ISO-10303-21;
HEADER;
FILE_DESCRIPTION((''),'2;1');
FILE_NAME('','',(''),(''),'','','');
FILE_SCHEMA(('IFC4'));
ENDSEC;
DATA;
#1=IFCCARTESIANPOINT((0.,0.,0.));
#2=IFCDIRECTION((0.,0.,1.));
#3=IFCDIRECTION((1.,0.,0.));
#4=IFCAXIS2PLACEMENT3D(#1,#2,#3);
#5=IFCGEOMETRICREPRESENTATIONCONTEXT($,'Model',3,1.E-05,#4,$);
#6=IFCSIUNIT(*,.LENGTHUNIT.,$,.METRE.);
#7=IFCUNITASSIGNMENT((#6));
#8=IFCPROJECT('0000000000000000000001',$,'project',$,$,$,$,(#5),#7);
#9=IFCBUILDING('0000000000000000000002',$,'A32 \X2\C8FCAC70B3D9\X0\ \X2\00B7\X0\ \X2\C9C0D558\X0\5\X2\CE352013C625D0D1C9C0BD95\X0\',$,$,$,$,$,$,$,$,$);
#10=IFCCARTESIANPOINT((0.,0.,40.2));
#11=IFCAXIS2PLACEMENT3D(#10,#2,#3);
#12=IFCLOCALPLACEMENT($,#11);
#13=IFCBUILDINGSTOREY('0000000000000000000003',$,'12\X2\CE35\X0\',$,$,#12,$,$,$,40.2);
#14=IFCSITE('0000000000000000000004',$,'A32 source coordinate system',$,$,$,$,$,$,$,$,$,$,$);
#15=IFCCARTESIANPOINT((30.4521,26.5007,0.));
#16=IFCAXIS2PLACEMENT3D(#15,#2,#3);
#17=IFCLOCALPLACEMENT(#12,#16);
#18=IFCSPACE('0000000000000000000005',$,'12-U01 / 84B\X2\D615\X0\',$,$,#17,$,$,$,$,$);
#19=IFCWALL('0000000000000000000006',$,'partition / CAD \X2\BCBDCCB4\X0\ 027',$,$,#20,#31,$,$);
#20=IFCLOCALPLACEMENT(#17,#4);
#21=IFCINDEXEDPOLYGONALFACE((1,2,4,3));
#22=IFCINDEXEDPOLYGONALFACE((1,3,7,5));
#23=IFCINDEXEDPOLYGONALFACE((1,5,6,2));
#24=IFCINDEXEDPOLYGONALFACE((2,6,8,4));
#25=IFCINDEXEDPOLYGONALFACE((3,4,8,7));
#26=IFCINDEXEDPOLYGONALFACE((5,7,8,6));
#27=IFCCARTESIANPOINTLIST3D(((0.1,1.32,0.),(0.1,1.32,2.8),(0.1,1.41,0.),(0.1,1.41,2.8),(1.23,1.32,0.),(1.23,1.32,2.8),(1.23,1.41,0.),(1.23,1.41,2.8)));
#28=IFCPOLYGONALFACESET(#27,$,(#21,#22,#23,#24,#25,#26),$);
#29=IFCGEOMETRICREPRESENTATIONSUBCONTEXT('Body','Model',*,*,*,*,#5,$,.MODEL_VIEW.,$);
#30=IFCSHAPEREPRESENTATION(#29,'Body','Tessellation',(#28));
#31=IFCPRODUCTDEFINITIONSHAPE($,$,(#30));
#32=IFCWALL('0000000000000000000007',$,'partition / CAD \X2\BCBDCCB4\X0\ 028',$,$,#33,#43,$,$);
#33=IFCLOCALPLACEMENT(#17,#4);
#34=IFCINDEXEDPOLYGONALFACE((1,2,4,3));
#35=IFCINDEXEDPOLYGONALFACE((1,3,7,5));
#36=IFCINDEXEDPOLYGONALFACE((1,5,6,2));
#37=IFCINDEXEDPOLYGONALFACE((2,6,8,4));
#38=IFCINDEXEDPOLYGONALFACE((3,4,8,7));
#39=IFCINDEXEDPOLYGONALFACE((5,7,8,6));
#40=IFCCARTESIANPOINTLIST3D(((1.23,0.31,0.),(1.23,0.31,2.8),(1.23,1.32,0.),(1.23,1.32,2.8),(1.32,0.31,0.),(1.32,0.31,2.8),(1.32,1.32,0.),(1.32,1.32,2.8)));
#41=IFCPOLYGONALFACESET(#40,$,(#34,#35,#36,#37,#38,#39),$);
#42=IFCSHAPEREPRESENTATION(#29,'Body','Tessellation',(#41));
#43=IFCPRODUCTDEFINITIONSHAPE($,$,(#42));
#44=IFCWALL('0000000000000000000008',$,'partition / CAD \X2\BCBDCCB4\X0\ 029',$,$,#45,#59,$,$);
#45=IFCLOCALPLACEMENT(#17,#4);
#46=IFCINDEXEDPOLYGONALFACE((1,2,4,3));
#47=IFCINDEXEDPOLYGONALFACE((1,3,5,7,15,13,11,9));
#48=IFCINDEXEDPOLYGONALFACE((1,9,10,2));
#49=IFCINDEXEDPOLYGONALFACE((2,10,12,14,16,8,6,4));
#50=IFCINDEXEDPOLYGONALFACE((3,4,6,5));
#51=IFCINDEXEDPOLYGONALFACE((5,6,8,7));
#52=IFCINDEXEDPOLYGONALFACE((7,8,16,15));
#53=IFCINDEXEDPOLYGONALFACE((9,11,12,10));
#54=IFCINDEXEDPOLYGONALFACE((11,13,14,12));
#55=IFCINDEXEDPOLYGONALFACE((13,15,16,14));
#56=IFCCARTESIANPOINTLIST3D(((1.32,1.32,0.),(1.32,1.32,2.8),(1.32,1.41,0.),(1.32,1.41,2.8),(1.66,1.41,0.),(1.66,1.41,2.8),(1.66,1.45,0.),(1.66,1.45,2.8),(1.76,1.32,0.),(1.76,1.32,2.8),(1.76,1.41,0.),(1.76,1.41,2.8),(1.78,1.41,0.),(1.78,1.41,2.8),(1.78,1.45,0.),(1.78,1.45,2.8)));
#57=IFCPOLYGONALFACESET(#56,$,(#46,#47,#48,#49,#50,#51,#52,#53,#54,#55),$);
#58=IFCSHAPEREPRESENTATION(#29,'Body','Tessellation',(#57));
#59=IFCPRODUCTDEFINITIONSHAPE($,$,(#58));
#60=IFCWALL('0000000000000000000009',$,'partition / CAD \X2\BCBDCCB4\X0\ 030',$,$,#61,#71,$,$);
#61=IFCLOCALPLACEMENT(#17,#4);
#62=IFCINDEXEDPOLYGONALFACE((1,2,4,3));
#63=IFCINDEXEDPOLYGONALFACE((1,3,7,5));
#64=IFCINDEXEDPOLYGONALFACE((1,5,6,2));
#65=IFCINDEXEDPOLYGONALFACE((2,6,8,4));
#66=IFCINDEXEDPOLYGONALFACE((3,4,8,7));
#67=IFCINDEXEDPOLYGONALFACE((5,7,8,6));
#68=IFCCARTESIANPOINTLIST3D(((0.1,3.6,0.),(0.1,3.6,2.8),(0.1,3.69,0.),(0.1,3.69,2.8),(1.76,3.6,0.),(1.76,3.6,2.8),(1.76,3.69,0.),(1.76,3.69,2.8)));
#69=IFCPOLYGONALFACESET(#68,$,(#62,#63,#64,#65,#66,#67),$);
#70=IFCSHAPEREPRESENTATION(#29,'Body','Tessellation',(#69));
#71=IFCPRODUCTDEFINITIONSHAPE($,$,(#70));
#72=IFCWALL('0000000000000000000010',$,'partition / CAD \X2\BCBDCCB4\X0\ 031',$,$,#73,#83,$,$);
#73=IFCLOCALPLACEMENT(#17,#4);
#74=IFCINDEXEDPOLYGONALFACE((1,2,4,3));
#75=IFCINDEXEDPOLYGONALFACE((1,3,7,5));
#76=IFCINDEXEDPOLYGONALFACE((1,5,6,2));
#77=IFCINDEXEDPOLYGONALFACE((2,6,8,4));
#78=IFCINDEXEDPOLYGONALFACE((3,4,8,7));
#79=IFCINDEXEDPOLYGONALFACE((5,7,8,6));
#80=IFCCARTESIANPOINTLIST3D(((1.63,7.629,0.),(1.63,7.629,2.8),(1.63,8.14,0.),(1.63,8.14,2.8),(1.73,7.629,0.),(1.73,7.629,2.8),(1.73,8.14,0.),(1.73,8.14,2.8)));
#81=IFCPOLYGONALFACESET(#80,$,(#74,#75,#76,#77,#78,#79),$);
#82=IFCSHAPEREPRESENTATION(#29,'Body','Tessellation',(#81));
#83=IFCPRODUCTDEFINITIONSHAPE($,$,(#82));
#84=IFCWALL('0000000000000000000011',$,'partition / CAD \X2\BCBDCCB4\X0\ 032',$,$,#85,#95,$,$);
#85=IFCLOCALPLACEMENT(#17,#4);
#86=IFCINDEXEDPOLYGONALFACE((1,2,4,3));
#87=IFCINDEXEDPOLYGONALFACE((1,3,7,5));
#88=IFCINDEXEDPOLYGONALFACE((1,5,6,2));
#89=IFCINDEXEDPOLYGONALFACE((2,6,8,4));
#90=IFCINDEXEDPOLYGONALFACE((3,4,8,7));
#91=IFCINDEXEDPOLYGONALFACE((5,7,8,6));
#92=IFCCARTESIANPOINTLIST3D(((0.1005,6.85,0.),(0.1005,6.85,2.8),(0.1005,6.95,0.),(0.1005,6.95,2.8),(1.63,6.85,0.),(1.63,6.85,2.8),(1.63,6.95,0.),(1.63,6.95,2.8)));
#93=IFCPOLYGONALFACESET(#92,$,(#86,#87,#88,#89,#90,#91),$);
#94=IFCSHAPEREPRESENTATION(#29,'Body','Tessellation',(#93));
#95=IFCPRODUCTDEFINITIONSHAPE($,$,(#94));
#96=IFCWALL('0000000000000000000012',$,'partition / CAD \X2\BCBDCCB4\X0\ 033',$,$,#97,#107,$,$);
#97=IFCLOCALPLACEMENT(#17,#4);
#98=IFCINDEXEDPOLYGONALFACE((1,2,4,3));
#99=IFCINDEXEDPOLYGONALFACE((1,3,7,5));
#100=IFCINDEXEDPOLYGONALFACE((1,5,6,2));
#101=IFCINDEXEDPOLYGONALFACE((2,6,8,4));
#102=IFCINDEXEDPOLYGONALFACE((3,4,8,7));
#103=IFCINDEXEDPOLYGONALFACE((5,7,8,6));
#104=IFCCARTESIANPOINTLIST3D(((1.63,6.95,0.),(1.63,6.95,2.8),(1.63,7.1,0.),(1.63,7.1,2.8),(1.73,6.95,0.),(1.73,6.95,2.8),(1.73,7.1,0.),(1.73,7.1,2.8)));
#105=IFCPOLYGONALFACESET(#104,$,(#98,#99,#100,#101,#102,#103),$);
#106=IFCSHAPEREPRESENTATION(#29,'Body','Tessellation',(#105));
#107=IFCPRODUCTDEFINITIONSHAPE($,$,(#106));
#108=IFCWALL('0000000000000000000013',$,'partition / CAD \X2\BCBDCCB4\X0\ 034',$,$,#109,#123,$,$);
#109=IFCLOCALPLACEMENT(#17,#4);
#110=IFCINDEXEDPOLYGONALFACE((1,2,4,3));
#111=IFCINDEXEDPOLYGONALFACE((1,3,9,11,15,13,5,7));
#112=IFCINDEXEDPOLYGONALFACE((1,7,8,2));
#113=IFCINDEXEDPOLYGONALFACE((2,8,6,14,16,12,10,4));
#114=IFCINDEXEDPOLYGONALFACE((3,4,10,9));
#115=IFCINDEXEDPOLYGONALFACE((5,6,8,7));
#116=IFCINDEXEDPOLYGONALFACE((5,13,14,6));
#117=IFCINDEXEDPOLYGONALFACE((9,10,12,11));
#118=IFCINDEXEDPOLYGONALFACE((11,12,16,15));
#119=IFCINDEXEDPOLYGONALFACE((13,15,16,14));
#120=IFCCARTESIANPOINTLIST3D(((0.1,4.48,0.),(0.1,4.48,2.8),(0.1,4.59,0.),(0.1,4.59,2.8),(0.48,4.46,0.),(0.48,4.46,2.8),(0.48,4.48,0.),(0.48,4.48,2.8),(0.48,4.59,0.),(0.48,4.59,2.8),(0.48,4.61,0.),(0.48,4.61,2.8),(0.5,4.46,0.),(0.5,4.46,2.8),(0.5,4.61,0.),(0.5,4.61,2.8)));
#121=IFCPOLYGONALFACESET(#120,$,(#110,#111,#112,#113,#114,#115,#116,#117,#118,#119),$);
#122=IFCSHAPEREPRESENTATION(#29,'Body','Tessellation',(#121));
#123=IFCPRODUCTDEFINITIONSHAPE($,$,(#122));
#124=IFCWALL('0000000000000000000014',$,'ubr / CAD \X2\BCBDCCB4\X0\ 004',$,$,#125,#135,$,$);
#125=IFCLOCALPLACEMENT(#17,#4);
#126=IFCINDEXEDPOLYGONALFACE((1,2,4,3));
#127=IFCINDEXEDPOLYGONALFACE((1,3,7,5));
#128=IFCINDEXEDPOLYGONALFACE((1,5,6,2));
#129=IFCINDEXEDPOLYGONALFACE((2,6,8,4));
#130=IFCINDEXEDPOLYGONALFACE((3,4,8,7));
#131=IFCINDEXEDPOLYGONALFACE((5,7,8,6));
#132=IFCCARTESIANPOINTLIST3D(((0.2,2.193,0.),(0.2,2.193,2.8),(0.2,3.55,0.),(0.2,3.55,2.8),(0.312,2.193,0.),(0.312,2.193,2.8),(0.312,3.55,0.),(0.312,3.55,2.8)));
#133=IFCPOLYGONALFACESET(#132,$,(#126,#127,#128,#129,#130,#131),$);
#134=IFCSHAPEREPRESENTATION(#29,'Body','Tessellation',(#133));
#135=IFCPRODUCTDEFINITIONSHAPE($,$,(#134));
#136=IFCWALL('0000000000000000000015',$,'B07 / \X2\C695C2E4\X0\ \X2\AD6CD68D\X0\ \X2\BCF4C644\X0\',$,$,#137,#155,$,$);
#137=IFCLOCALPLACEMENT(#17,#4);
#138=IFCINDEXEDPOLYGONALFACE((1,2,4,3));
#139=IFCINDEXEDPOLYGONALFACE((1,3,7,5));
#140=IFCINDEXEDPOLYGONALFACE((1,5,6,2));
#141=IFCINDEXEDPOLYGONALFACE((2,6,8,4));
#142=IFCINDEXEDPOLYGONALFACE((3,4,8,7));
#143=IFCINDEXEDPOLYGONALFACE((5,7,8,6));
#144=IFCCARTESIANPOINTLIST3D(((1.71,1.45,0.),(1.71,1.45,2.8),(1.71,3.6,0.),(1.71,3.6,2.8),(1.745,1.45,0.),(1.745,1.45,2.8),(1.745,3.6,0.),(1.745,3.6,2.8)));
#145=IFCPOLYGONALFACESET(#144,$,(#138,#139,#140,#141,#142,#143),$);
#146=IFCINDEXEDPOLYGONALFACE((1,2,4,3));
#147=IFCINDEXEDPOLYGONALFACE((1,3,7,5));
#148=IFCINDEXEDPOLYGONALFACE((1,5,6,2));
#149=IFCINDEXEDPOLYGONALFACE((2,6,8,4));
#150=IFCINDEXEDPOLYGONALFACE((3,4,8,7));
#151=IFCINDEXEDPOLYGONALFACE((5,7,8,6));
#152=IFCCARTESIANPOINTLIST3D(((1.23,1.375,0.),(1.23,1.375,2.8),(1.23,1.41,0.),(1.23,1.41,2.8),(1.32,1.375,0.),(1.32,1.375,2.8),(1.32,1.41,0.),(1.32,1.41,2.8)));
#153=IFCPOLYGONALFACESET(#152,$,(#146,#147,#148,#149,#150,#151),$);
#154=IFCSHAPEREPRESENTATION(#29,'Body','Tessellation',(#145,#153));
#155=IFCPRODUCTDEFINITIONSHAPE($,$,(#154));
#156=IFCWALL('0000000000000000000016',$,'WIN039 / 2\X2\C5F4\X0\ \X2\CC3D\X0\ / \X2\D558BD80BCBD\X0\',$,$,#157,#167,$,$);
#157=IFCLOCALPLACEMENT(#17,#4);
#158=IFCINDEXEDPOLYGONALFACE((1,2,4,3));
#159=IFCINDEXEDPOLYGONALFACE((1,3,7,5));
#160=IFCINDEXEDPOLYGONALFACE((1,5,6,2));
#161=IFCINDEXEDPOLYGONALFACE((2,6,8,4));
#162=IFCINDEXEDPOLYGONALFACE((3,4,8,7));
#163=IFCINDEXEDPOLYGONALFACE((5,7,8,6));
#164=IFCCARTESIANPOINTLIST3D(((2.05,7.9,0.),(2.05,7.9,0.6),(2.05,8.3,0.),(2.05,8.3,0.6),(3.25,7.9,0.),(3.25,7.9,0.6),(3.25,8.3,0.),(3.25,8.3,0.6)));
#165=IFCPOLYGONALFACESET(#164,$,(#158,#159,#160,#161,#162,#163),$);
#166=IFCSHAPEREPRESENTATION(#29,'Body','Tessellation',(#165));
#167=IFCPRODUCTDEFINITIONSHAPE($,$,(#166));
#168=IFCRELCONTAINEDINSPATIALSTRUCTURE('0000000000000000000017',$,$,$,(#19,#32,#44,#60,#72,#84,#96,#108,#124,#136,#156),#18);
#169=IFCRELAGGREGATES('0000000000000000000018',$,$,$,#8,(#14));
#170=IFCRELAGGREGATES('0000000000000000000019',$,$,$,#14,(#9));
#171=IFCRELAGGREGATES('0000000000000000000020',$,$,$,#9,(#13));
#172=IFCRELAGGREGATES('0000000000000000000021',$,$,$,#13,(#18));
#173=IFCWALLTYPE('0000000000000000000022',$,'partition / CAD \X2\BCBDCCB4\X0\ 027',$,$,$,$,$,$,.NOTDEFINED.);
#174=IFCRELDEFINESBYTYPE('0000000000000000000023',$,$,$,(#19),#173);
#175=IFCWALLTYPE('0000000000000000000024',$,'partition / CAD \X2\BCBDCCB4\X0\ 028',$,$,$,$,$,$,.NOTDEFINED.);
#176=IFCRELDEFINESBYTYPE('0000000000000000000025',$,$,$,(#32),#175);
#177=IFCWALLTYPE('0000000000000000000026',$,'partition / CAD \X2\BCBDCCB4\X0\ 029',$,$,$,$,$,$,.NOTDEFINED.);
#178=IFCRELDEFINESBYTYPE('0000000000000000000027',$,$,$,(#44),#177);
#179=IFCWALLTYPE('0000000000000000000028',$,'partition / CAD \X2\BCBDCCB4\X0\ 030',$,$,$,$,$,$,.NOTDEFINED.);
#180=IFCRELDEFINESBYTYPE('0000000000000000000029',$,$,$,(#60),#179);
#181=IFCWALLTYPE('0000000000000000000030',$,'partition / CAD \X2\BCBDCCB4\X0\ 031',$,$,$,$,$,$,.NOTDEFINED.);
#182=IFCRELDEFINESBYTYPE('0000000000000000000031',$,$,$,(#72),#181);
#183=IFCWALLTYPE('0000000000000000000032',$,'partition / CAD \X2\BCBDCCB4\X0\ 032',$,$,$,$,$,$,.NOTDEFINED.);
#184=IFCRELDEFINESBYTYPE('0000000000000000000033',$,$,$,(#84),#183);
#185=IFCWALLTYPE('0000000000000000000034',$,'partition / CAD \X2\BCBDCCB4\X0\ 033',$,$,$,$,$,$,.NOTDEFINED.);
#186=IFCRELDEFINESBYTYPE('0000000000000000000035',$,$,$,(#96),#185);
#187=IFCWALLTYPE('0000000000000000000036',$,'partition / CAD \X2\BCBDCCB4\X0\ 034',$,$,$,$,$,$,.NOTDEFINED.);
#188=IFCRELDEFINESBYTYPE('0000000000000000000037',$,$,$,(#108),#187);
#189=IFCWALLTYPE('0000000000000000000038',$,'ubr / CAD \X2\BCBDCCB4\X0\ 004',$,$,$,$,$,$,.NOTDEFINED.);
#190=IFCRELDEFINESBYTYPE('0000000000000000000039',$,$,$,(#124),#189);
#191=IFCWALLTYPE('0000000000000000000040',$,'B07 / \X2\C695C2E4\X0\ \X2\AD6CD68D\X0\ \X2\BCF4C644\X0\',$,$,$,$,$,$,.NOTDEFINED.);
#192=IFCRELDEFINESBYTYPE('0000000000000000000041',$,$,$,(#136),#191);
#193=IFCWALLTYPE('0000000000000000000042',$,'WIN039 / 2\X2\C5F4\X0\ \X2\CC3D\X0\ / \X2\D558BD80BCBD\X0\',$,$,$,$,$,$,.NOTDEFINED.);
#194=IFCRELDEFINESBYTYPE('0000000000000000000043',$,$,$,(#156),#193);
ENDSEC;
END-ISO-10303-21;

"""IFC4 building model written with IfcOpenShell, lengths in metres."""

from ifc_helpers import new_model, si_unit, frame, origin, origin_with_axes, place, context, subcontext, project, spatial, polyline, outline, extrude, source, transform, mapped, type_object, type_shapes, element, save


model = new_model("IFC4")

# Units and contexts
model_context = context("Model", 3, precision=1e-05, world=origin_with_axes())
body_context = subcontext(model_context, "Body", "Model", "MODEL_VIEW")
ifc_project = project(units=[si_unit("LENGTHUNIT", "METRE")], contexts=[model_context])

# Site, building, storey, space
site = spatial("IfcSite", under=ifc_project, Name="A32 source coordinate system")
building = spatial("IfcBuilding", under=site, Name="A32 주거동 · 지하5층–옥탑지붕")
storey_placement = place(None, frame((0.0, 0.0, 40.2), z_axis=(0.0, 0.0, 1.0), x_axis=(1.0, 0.0, 0.0)))
storey = spatial("IfcBuildingStorey", under=building, at=storey_placement, Name="12층", Elevation=40.2)
space_placement = place(storey_placement, frame((30.4521, 26.5007, 0.0), z_axis=(0.0, 0.0, 1.0), x_axis=(1.0, 0.0, 0.0)))
space = spatial("IfcSpace", under=storey, at=space_placement, Name="12-U01 / 84B형")

# Walls
wall_type_1 = type_object("IfcWallType", Name="partition / CAD 벽체 027", PredefinedType="NOTDEFINED")
shared_shape_1 = source(origin(), body_context, "Body", "SweptSolid", [
    extrude(outline(polyline([(0.1, 1.32), (0.1, 1.41), (1.23, 1.41), (1.23, 1.32), (0.1, 1.32)])), origin(), (0.0, 0.0, 1.0), 2.8),
])
type_shapes(wall_type_1, [shared_shape_1])
wall_1_placement = place(space_placement, origin_with_axes())
element("IfcWall", 1, at=wall_1_placement, inside=space, type_object=wall_type_1, Name="partition / CAD 벽체 027", context=body_context, shape_type="MappedRepresentation", body=[
    mapped(shared_shape_1, transform((0.0, 0.0, 0.0), scale=1.0)),
])
wall_type_2 = type_object("IfcWallType", Name="partition / CAD 벽체 028", PredefinedType="NOTDEFINED")
shared_shape_2 = source(origin(), body_context, "Body", "SweptSolid", [
    extrude(outline(polyline([(1.32, 0.31), (1.23, 0.31), (1.23, 1.32), (1.32, 1.32), (1.32, 0.31)])), origin(), (0.0, 0.0, 1.0), 2.8),
])
type_shapes(wall_type_2, [shared_shape_2])
wall_2_placement = place(space_placement, origin_with_axes())
element("IfcWall", 2, at=wall_2_placement, inside=space, type_object=wall_type_2, Name="partition / CAD 벽체 028", context=body_context, shape_type="MappedRepresentation", body=[
    mapped(shared_shape_2, transform((0.0, 0.0, 0.0), scale=1.0)),
])
wall_type_3 = type_object("IfcWallType", Name="partition / CAD 벽체 029", PredefinedType="NOTDEFINED")
shared_shape_3 = source(origin(), body_context, "Body", "SweptSolid", [
    extrude(outline(polyline([(1.66, 1.41), (1.66, 1.45), (1.78, 1.45), (1.78, 1.41), (1.76, 1.41), (1.76, 1.32), (1.32, 1.32), (1.32, 1.41), (1.66, 1.41)])), origin(), (0.0, 0.0, 1.0), 2.8),
])
type_shapes(wall_type_3, [shared_shape_3])
wall_3_placement = place(space_placement, origin_with_axes())
element("IfcWall", 3, at=wall_3_placement, inside=space, type_object=wall_type_3, Name="partition / CAD 벽체 029", context=body_context, shape_type="MappedRepresentation", body=[
    mapped(shared_shape_3, transform((0.0, 0.0, 0.0), scale=1.0)),
])
wall_type_4 = type_object("IfcWallType", Name="partition / CAD 벽체 030", PredefinedType="NOTDEFINED")
shared_shape_4 = source(origin(), body_context, "Body", "SweptSolid", [
    extrude(outline(polyline([(1.76, 3.69), (1.76, 3.6), (0.1, 3.6), (0.1, 3.69), (1.76, 3.69)])), origin(), (0.0, 0.0, 1.0), 2.8),
])
type_shapes(wall_type_4, [shared_shape_4])
wall_4_placement = place(space_placement, origin_with_axes())
element("IfcWall", 4, at=wall_4_placement, inside=space, type_object=wall_type_4, Name="partition / CAD 벽체 030", context=body_context, shape_type="MappedRepresentation", body=[
    mapped(shared_shape_4, transform((0.0, 0.0, 0.0), scale=1.0)),
])
wall_type_5 = type_object("IfcWallType", Name="partition / CAD 벽체 031", PredefinedType="NOTDEFINED")
shared_shape_5 = source(origin(), body_context, "Body", "SweptSolid", [
    extrude(outline(polyline([(1.63, 8.14), (1.73, 8.14), (1.73, 7.629), (1.63, 7.629), (1.63, 8.14)])), origin(), (0.0, 0.0, 1.0), 2.8),
])
type_shapes(wall_type_5, [shared_shape_5])
wall_5_placement = place(space_placement, origin_with_axes())
element("IfcWall", 5, at=wall_5_placement, inside=space, type_object=wall_type_5, Name="partition / CAD 벽체 031", context=body_context, shape_type="MappedRepresentation", body=[
    mapped(shared_shape_5, transform((0.0, 0.0, 0.0), scale=1.0)),
])
wall_type_6 = type_object("IfcWallType", Name="partition / CAD 벽체 032", PredefinedType="NOTDEFINED")
shared_shape_6 = source(origin(), body_context, "Body", "SweptSolid", [
    extrude(outline(polyline([(0.1005, 6.95), (1.63, 6.95), (1.63, 6.85), (0.1005, 6.85), (0.1005, 6.95)])), origin(), (0.0, 0.0, 1.0), 2.8),
])
type_shapes(wall_type_6, [shared_shape_6])
wall_6_placement = place(space_placement, origin_with_axes())
element("IfcWall", 6, at=wall_6_placement, inside=space, type_object=wall_type_6, Name="partition / CAD 벽체 032", context=body_context, shape_type="MappedRepresentation", body=[
    mapped(shared_shape_6, transform((0.0, 0.0, 0.0), scale=1.0)),
])
wall_type_7 = type_object("IfcWallType", Name="partition / CAD 벽체 033", PredefinedType="NOTDEFINED")
shared_shape_7 = source(origin(), body_context, "Body", "SweptSolid", [
    extrude(outline(polyline([(1.63, 7.1), (1.73, 7.1), (1.73, 6.95), (1.63, 6.95), (1.63, 7.1)])), origin(), (0.0, 0.0, 1.0), 2.8),
])
type_shapes(wall_type_7, [shared_shape_7])
wall_7_placement = place(space_placement, origin_with_axes())
element("IfcWall", 7, at=wall_7_placement, inside=space, type_object=wall_type_7, Name="partition / CAD 벽체 033", context=body_context, shape_type="MappedRepresentation", body=[
    mapped(shared_shape_7, transform((0.0, 0.0, 0.0), scale=1.0)),
])
wall_type_8 = type_object("IfcWallType", Name="partition / CAD 벽체 034", PredefinedType="NOTDEFINED")
shared_shape_8 = source(origin(), body_context, "Body", "SweptSolid", [
    extrude(outline(polyline([(0.48, 4.61), (0.5, 4.61), (0.5, 4.46), (0.48, 4.46), (0.48, 4.48), (0.1, 4.48), (0.1, 4.59), (0.48, 4.59), (0.48, 4.61)])), origin(), (0.0, 0.0, 1.0), 2.8),
])
type_shapes(wall_type_8, [shared_shape_8])
wall_8_placement = place(space_placement, origin_with_axes())
element("IfcWall", 8, at=wall_8_placement, inside=space, type_object=wall_type_8, Name="partition / CAD 벽체 034", context=body_context, shape_type="MappedRepresentation", body=[
    mapped(shared_shape_8, transform((0.0, 0.0, 0.0), scale=1.0)),
])
wall_type_9 = type_object("IfcWallType", Name="ubr / CAD 벽체 004", PredefinedType="NOTDEFINED")
shared_shape_9 = source(origin(), body_context, "Body", "SweptSolid", [
    extrude(outline(polyline([(0.312, 2.193), (0.2, 2.193), (0.2, 3.55), (0.312, 3.55), (0.312, 2.193)])), origin(), (0.0, 0.0, 1.0), 2.8),
])
type_shapes(wall_type_9, [shared_shape_9])
wall_9_placement = place(space_placement, origin_with_axes())
element("IfcWall", 9, at=wall_9_placement, inside=space, type_object=wall_type_9, Name="ubr / CAD 벽체 004", context=body_context, shape_type="MappedRepresentation", body=[
    mapped(shared_shape_9, transform((0.0, 0.0, 0.0), scale=1.0)),
])
wall_type_10 = type_object("IfcWallType", Name="B07 / 욕실 구획 보완", PredefinedType="NOTDEFINED")
shared_shape_10 = source(origin(), body_context, "Body", "SweptSolid", [
    extrude(outline(polyline([(1.71, 1.45), (1.71, 3.6), (1.745, 3.6), (1.745, 1.45), (1.71, 1.45)])), origin(), (0.0, 0.0, 1.0), 2.8),
    extrude(outline(polyline([(1.32, 1.41), (1.32, 1.375), (1.23, 1.375), (1.23, 1.41), (1.32, 1.41)])), origin(), (0.0, 0.0, 1.0), 2.8),
])
type_shapes(wall_type_10, [shared_shape_10])
wall_10_placement = place(space_placement, origin_with_axes())
element("IfcWall", 10, at=wall_10_placement, inside=space, type_object=wall_type_10, Name="B07 / 욕실 구획 보완", context=body_context, shape_type="MappedRepresentation", body=[
    mapped(shared_shape_10, transform((0.0, 0.0, 0.0), scale=1.0)),
])
wall_type_11 = type_object("IfcWallType", Name="WIN039 / 2열 창 / 하부벽", PredefinedType="NOTDEFINED")
shared_shape_11 = source(origin(), body_context, "Body", "SweptSolid", [
    extrude(outline(polyline([(2.05, 8.3), (3.25, 8.3), (3.25, 7.9), (2.05, 7.9), (2.05, 8.3)])), origin(), (0.0, 0.0, 1.0), 0.6),
])
type_shapes(wall_type_11, [shared_shape_11])
wall_11_placement = place(space_placement, origin_with_axes())
element("IfcWall", 11, at=wall_11_placement, inside=space, type_object=wall_type_11, Name="WIN039 / 2열 창 / 하부벽", context=body_context, shape_type="MappedRepresentation", body=[
    mapped(shared_shape_11, transform((0.0, 0.0, 0.0), scale=1.0)),
])

save(model, "model.ifc")
